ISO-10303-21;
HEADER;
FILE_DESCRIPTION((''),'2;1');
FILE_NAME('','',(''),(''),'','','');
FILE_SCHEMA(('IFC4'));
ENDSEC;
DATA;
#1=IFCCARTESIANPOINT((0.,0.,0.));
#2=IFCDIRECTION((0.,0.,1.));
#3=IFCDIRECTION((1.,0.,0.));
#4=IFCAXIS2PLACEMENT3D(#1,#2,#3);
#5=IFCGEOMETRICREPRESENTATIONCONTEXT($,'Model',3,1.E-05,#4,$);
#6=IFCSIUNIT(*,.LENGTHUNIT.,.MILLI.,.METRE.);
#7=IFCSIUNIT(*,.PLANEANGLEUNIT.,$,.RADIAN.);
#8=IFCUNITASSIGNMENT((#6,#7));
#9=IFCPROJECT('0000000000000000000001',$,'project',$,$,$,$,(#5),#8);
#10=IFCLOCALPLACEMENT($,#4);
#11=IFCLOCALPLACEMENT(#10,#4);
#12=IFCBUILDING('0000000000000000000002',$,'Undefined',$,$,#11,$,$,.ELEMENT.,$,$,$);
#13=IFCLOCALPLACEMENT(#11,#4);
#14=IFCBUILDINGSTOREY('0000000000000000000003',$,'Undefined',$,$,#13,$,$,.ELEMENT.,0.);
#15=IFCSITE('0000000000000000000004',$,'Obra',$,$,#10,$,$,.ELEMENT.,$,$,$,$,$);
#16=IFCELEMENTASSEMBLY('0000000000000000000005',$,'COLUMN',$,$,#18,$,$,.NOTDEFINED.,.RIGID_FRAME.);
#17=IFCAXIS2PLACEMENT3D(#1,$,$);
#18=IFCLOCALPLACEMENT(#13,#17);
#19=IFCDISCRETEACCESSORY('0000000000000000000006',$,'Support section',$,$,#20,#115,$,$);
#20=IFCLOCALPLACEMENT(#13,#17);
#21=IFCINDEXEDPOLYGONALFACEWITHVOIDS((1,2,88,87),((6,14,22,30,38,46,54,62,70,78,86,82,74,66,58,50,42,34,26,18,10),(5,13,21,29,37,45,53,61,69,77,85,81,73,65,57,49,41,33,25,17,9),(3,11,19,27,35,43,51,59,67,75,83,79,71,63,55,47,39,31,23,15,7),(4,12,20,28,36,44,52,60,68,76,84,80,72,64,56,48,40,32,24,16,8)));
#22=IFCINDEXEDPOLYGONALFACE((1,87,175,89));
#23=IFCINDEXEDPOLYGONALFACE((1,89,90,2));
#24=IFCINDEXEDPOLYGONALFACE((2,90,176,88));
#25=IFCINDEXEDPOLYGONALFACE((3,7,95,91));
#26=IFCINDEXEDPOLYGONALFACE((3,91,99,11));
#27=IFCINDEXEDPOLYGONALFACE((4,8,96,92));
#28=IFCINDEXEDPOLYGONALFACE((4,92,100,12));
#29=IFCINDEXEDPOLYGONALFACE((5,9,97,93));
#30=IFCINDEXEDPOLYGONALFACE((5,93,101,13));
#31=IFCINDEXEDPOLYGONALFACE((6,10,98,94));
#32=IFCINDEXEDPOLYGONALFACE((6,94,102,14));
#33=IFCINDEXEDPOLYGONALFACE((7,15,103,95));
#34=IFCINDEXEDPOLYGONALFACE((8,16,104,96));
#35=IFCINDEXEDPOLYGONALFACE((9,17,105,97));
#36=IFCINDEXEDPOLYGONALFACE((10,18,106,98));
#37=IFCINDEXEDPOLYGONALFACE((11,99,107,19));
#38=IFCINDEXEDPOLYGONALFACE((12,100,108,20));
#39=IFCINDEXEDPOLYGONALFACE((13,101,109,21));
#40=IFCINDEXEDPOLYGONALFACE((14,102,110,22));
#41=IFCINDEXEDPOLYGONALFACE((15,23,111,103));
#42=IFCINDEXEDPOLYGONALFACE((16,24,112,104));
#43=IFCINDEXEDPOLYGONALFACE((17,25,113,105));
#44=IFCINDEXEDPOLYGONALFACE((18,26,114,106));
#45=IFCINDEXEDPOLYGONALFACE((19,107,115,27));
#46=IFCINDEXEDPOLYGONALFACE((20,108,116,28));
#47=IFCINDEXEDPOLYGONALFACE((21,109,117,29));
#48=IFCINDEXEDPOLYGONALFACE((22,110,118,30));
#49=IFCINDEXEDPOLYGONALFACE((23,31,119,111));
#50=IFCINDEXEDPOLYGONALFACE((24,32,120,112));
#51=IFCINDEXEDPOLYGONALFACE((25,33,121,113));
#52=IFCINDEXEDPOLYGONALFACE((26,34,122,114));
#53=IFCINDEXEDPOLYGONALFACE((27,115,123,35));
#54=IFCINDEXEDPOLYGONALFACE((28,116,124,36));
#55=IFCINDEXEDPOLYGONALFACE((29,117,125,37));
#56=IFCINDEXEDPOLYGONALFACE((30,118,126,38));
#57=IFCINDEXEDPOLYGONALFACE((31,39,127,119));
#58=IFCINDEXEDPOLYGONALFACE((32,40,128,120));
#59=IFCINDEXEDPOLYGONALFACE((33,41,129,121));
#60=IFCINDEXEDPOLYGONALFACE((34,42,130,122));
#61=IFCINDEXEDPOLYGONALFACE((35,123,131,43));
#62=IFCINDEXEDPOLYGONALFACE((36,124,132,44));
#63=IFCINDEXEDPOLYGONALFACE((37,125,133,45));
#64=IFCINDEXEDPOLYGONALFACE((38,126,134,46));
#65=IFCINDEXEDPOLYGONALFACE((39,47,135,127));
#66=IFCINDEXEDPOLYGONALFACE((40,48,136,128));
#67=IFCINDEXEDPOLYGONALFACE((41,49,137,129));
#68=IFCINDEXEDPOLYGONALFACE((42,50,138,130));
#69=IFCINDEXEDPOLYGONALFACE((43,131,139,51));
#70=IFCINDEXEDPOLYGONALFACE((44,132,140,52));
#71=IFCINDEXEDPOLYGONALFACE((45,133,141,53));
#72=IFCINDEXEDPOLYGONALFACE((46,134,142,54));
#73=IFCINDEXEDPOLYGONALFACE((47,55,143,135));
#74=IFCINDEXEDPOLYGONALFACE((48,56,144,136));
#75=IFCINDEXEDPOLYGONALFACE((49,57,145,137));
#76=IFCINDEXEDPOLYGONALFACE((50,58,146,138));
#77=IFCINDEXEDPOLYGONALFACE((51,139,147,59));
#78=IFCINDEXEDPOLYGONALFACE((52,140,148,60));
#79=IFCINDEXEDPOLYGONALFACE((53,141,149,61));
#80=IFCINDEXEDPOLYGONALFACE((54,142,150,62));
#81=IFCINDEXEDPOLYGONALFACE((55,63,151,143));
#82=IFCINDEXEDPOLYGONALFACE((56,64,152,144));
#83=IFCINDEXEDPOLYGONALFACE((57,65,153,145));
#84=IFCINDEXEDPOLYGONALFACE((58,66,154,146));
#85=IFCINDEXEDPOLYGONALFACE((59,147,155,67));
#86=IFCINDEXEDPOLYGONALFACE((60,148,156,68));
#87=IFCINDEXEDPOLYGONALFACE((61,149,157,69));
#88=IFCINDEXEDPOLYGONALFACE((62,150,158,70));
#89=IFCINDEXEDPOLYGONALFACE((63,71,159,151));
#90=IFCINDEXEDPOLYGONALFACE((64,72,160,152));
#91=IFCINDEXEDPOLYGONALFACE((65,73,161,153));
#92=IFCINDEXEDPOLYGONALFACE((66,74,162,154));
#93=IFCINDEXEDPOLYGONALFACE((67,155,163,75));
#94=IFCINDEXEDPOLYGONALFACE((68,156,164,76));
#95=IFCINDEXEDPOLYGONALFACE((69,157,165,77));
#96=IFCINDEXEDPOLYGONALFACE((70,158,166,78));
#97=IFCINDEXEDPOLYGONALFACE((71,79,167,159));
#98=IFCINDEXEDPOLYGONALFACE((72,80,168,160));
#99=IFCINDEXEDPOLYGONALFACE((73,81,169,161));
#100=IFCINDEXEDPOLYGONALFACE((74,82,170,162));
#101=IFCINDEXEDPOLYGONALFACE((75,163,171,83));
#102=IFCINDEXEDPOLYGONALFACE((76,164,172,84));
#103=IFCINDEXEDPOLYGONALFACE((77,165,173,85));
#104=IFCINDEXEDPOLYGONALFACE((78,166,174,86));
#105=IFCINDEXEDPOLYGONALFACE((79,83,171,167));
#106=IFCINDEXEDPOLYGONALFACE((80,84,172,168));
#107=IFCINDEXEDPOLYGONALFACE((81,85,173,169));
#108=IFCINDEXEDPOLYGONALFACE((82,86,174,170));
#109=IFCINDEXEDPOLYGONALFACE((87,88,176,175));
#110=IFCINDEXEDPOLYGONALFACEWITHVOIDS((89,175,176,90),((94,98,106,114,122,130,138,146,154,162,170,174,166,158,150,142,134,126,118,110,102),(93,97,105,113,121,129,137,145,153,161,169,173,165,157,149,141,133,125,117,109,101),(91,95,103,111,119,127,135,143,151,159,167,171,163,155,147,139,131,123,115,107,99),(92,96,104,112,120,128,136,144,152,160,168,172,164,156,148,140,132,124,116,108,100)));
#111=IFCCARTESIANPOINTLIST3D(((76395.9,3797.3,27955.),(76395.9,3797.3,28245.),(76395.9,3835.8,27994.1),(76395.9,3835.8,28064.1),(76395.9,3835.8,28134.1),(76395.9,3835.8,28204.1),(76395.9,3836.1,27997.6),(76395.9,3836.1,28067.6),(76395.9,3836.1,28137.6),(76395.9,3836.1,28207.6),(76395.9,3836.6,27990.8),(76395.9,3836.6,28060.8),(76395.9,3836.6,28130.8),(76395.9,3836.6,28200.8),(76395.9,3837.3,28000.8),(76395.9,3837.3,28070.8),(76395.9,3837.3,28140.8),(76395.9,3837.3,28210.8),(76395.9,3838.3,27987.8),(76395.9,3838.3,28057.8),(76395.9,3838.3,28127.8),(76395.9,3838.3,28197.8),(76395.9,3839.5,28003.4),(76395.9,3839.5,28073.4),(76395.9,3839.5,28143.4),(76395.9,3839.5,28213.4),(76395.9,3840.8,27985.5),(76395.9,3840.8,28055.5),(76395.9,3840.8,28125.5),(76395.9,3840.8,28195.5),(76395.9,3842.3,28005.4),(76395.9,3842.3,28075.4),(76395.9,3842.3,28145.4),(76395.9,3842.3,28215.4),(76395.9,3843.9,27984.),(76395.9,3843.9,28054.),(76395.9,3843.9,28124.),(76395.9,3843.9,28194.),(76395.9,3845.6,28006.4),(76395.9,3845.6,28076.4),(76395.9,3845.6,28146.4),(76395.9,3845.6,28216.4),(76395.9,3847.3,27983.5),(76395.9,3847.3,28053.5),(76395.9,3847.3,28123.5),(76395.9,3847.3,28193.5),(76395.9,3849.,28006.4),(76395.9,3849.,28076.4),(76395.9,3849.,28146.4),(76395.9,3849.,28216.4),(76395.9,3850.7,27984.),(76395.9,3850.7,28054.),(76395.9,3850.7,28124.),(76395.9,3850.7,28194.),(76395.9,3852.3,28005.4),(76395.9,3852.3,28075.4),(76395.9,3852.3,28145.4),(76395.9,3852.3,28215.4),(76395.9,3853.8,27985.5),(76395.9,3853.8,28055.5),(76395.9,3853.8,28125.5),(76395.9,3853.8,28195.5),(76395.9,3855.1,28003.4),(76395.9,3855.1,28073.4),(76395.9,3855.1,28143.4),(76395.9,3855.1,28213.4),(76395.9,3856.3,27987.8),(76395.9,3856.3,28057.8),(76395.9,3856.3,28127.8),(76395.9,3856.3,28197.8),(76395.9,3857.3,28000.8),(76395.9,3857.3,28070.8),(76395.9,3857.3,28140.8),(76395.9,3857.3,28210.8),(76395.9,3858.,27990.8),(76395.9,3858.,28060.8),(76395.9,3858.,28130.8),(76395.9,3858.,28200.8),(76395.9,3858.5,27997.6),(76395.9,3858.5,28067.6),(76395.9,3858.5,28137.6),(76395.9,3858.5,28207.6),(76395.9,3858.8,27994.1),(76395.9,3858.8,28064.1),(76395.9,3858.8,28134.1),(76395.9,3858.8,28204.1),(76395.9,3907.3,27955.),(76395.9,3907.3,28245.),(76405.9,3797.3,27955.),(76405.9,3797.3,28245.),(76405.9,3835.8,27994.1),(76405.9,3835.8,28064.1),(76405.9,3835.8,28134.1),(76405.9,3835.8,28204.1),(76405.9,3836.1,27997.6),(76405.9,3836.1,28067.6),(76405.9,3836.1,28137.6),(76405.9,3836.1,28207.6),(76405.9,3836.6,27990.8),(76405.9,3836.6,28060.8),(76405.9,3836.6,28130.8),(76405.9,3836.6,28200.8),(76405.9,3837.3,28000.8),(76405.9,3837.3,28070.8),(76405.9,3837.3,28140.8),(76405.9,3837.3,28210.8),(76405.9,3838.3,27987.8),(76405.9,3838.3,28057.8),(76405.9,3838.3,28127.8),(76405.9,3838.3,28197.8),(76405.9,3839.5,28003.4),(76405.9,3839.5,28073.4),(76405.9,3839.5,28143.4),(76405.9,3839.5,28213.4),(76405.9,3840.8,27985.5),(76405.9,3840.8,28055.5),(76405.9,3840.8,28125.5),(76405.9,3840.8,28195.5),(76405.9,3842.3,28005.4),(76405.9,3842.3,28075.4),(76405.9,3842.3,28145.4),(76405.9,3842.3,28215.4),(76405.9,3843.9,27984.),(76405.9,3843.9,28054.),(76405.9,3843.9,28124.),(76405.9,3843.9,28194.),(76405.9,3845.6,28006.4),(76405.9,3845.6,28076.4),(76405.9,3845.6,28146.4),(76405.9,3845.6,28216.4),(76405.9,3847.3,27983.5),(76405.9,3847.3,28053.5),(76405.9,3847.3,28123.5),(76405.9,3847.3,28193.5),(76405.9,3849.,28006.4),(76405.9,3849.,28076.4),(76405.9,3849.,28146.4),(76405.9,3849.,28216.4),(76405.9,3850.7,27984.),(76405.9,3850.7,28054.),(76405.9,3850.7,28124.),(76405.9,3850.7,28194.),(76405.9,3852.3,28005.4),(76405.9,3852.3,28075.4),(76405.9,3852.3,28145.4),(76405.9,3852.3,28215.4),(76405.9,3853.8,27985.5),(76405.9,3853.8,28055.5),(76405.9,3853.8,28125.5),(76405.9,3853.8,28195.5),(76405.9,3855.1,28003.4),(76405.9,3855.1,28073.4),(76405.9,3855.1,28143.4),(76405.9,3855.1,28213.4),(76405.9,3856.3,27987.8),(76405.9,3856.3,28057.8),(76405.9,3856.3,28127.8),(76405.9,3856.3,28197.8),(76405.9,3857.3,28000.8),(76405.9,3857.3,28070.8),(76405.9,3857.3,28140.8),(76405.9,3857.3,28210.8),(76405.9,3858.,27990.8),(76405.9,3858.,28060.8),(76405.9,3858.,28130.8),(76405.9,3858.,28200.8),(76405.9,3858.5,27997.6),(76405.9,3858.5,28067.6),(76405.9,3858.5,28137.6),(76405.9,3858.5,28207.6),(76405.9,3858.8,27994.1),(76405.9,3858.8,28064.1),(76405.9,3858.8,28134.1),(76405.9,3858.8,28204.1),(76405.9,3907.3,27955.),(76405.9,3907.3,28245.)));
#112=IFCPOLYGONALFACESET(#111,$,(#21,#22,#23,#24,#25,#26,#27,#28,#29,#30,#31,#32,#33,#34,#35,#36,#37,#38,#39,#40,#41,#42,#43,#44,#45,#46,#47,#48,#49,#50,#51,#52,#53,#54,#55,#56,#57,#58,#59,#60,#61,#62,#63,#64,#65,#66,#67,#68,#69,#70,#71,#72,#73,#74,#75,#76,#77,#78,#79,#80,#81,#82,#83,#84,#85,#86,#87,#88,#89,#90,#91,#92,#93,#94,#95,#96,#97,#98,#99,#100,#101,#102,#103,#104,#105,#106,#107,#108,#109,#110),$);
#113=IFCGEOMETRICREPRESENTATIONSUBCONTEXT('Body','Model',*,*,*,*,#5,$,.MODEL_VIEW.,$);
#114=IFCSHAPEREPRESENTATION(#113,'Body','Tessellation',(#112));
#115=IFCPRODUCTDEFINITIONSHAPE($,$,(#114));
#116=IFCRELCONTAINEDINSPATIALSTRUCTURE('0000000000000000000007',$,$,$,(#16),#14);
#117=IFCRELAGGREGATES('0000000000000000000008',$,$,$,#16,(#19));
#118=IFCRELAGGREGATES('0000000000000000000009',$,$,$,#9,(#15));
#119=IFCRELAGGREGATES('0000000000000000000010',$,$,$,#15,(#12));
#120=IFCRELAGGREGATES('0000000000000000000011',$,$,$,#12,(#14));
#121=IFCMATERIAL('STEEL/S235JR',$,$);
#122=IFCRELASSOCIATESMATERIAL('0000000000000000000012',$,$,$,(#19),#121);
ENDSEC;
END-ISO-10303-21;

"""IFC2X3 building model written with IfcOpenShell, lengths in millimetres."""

from ifc_helpers import new_model, si_unit, frame, origin_with_axes, origin_2d_with_axis, place, context, subcontext, project, spatial, rectangle, circle, extrude, source, transform, mapped, material, element, aggregate, save


model = new_model("IFC2X3")

# Units and contexts
model_context = context("Model", 3, precision=1e-05, world=origin_with_axes())
body_context = subcontext(model_context, "Body", "Model", "MODEL_VIEW")
ifc_project = project(units=[si_unit("LENGTHUNIT", "METRE", prefix="MILLI"), si_unit("PLANEANGLEUNIT", "RADIAN")], contexts=[model_context])

# Site, building, storey
site_placement = place(None, origin_with_axes())
site = spatial("IfcSite", under=ifc_project, at=site_placement, Name="Obra", CompositionType="ELEMENT")
building_placement = place(site_placement, origin_with_axes())
building = spatial("IfcBuilding", under=site, at=building_placement, Name="Undefined", CompositionType="ELEMENT")
storey_placement = place(building_placement, origin_with_axes())
storey = spatial("IfcBuildingStorey", under=building, at=storey_placement, Name="Undefined", CompositionType="ELEMENT", Elevation=0.0)

# Element assembly
assembly_1_placement = place(storey_placement, origin_with_axes())
assembly_1 = element("IfcElementAssembly", 1, at=assembly_1_placement, inside=storey, Name="COLUMN", AssemblyPlace="NOTDEFINED", PredefinedType="RIGID_FRAME")
ifc_material_1 = material(Name="STEEL/S235JR")

# Discrete accessory, opening
shared_shape_1 = source(origin_with_axes(), body_context, "Body", "SweptSolid", [
    extrude(circle(Radius=11.5, at=origin_2d_with_axis()), frame((0.0, -14.4, 0.0), z_axis=(0.0, 1.0, 0.0), x_axis=(1.0, 0.0, 0.0)), (0.0, 0.0, 1.0), 10.2),
])
discrete_accessory_1_placement = place(assembly_1_placement, frame((76400.9, 3852.3, 27955.0), z_axis=(0.0, 0.0, 1.0), x_axis=(0.0, 1.0, 0.0)))
discrete_accessory_1 = element("IfcDiscreteAccessory", 2, at=discrete_accessory_1_placement, material=ifc_material_1, Name="Support section", context=body_context, shape_type="SweptSolid", body=[
    extrude(rectangle(XDim=10.0, YDim=110.0, at=origin_2d_with_axis()), frame((0.0, 0.0, 290.0), z_axis=(0.0, 0.0, -1.0), x_axis=(0.0, 1.0, 0.0)), (0.0, 0.0, 1.0), 290.0),
])
opening_1_placement = place(assembly_1_placement, frame((76410.2, 3897.3, 28300.0), z_axis=(0.0, -1.0, 0.0), x_axis=(0.0, 0.0, -1.0)))
element("IfcOpeningElement", 3, at=opening_1_placement, cuts=discrete_accessory_1, ObjectType="Opening", context=body_context, shape_type="MappedRepresentation", body=[
    mapped(shared_shape_1, transform((95.0, 0.0, 50.0))),
    mapped(shared_shape_1, transform((165.0, 0.0, 50.0))),
    mapped(shared_shape_1, transform((235.0, 0.0, 50.0))),
    mapped(shared_shape_1, transform((305.0, 0.0, 50.0))),
])
aggregate(assembly_1, [discrete_accessory_1])

save(model, "model.ifc")
